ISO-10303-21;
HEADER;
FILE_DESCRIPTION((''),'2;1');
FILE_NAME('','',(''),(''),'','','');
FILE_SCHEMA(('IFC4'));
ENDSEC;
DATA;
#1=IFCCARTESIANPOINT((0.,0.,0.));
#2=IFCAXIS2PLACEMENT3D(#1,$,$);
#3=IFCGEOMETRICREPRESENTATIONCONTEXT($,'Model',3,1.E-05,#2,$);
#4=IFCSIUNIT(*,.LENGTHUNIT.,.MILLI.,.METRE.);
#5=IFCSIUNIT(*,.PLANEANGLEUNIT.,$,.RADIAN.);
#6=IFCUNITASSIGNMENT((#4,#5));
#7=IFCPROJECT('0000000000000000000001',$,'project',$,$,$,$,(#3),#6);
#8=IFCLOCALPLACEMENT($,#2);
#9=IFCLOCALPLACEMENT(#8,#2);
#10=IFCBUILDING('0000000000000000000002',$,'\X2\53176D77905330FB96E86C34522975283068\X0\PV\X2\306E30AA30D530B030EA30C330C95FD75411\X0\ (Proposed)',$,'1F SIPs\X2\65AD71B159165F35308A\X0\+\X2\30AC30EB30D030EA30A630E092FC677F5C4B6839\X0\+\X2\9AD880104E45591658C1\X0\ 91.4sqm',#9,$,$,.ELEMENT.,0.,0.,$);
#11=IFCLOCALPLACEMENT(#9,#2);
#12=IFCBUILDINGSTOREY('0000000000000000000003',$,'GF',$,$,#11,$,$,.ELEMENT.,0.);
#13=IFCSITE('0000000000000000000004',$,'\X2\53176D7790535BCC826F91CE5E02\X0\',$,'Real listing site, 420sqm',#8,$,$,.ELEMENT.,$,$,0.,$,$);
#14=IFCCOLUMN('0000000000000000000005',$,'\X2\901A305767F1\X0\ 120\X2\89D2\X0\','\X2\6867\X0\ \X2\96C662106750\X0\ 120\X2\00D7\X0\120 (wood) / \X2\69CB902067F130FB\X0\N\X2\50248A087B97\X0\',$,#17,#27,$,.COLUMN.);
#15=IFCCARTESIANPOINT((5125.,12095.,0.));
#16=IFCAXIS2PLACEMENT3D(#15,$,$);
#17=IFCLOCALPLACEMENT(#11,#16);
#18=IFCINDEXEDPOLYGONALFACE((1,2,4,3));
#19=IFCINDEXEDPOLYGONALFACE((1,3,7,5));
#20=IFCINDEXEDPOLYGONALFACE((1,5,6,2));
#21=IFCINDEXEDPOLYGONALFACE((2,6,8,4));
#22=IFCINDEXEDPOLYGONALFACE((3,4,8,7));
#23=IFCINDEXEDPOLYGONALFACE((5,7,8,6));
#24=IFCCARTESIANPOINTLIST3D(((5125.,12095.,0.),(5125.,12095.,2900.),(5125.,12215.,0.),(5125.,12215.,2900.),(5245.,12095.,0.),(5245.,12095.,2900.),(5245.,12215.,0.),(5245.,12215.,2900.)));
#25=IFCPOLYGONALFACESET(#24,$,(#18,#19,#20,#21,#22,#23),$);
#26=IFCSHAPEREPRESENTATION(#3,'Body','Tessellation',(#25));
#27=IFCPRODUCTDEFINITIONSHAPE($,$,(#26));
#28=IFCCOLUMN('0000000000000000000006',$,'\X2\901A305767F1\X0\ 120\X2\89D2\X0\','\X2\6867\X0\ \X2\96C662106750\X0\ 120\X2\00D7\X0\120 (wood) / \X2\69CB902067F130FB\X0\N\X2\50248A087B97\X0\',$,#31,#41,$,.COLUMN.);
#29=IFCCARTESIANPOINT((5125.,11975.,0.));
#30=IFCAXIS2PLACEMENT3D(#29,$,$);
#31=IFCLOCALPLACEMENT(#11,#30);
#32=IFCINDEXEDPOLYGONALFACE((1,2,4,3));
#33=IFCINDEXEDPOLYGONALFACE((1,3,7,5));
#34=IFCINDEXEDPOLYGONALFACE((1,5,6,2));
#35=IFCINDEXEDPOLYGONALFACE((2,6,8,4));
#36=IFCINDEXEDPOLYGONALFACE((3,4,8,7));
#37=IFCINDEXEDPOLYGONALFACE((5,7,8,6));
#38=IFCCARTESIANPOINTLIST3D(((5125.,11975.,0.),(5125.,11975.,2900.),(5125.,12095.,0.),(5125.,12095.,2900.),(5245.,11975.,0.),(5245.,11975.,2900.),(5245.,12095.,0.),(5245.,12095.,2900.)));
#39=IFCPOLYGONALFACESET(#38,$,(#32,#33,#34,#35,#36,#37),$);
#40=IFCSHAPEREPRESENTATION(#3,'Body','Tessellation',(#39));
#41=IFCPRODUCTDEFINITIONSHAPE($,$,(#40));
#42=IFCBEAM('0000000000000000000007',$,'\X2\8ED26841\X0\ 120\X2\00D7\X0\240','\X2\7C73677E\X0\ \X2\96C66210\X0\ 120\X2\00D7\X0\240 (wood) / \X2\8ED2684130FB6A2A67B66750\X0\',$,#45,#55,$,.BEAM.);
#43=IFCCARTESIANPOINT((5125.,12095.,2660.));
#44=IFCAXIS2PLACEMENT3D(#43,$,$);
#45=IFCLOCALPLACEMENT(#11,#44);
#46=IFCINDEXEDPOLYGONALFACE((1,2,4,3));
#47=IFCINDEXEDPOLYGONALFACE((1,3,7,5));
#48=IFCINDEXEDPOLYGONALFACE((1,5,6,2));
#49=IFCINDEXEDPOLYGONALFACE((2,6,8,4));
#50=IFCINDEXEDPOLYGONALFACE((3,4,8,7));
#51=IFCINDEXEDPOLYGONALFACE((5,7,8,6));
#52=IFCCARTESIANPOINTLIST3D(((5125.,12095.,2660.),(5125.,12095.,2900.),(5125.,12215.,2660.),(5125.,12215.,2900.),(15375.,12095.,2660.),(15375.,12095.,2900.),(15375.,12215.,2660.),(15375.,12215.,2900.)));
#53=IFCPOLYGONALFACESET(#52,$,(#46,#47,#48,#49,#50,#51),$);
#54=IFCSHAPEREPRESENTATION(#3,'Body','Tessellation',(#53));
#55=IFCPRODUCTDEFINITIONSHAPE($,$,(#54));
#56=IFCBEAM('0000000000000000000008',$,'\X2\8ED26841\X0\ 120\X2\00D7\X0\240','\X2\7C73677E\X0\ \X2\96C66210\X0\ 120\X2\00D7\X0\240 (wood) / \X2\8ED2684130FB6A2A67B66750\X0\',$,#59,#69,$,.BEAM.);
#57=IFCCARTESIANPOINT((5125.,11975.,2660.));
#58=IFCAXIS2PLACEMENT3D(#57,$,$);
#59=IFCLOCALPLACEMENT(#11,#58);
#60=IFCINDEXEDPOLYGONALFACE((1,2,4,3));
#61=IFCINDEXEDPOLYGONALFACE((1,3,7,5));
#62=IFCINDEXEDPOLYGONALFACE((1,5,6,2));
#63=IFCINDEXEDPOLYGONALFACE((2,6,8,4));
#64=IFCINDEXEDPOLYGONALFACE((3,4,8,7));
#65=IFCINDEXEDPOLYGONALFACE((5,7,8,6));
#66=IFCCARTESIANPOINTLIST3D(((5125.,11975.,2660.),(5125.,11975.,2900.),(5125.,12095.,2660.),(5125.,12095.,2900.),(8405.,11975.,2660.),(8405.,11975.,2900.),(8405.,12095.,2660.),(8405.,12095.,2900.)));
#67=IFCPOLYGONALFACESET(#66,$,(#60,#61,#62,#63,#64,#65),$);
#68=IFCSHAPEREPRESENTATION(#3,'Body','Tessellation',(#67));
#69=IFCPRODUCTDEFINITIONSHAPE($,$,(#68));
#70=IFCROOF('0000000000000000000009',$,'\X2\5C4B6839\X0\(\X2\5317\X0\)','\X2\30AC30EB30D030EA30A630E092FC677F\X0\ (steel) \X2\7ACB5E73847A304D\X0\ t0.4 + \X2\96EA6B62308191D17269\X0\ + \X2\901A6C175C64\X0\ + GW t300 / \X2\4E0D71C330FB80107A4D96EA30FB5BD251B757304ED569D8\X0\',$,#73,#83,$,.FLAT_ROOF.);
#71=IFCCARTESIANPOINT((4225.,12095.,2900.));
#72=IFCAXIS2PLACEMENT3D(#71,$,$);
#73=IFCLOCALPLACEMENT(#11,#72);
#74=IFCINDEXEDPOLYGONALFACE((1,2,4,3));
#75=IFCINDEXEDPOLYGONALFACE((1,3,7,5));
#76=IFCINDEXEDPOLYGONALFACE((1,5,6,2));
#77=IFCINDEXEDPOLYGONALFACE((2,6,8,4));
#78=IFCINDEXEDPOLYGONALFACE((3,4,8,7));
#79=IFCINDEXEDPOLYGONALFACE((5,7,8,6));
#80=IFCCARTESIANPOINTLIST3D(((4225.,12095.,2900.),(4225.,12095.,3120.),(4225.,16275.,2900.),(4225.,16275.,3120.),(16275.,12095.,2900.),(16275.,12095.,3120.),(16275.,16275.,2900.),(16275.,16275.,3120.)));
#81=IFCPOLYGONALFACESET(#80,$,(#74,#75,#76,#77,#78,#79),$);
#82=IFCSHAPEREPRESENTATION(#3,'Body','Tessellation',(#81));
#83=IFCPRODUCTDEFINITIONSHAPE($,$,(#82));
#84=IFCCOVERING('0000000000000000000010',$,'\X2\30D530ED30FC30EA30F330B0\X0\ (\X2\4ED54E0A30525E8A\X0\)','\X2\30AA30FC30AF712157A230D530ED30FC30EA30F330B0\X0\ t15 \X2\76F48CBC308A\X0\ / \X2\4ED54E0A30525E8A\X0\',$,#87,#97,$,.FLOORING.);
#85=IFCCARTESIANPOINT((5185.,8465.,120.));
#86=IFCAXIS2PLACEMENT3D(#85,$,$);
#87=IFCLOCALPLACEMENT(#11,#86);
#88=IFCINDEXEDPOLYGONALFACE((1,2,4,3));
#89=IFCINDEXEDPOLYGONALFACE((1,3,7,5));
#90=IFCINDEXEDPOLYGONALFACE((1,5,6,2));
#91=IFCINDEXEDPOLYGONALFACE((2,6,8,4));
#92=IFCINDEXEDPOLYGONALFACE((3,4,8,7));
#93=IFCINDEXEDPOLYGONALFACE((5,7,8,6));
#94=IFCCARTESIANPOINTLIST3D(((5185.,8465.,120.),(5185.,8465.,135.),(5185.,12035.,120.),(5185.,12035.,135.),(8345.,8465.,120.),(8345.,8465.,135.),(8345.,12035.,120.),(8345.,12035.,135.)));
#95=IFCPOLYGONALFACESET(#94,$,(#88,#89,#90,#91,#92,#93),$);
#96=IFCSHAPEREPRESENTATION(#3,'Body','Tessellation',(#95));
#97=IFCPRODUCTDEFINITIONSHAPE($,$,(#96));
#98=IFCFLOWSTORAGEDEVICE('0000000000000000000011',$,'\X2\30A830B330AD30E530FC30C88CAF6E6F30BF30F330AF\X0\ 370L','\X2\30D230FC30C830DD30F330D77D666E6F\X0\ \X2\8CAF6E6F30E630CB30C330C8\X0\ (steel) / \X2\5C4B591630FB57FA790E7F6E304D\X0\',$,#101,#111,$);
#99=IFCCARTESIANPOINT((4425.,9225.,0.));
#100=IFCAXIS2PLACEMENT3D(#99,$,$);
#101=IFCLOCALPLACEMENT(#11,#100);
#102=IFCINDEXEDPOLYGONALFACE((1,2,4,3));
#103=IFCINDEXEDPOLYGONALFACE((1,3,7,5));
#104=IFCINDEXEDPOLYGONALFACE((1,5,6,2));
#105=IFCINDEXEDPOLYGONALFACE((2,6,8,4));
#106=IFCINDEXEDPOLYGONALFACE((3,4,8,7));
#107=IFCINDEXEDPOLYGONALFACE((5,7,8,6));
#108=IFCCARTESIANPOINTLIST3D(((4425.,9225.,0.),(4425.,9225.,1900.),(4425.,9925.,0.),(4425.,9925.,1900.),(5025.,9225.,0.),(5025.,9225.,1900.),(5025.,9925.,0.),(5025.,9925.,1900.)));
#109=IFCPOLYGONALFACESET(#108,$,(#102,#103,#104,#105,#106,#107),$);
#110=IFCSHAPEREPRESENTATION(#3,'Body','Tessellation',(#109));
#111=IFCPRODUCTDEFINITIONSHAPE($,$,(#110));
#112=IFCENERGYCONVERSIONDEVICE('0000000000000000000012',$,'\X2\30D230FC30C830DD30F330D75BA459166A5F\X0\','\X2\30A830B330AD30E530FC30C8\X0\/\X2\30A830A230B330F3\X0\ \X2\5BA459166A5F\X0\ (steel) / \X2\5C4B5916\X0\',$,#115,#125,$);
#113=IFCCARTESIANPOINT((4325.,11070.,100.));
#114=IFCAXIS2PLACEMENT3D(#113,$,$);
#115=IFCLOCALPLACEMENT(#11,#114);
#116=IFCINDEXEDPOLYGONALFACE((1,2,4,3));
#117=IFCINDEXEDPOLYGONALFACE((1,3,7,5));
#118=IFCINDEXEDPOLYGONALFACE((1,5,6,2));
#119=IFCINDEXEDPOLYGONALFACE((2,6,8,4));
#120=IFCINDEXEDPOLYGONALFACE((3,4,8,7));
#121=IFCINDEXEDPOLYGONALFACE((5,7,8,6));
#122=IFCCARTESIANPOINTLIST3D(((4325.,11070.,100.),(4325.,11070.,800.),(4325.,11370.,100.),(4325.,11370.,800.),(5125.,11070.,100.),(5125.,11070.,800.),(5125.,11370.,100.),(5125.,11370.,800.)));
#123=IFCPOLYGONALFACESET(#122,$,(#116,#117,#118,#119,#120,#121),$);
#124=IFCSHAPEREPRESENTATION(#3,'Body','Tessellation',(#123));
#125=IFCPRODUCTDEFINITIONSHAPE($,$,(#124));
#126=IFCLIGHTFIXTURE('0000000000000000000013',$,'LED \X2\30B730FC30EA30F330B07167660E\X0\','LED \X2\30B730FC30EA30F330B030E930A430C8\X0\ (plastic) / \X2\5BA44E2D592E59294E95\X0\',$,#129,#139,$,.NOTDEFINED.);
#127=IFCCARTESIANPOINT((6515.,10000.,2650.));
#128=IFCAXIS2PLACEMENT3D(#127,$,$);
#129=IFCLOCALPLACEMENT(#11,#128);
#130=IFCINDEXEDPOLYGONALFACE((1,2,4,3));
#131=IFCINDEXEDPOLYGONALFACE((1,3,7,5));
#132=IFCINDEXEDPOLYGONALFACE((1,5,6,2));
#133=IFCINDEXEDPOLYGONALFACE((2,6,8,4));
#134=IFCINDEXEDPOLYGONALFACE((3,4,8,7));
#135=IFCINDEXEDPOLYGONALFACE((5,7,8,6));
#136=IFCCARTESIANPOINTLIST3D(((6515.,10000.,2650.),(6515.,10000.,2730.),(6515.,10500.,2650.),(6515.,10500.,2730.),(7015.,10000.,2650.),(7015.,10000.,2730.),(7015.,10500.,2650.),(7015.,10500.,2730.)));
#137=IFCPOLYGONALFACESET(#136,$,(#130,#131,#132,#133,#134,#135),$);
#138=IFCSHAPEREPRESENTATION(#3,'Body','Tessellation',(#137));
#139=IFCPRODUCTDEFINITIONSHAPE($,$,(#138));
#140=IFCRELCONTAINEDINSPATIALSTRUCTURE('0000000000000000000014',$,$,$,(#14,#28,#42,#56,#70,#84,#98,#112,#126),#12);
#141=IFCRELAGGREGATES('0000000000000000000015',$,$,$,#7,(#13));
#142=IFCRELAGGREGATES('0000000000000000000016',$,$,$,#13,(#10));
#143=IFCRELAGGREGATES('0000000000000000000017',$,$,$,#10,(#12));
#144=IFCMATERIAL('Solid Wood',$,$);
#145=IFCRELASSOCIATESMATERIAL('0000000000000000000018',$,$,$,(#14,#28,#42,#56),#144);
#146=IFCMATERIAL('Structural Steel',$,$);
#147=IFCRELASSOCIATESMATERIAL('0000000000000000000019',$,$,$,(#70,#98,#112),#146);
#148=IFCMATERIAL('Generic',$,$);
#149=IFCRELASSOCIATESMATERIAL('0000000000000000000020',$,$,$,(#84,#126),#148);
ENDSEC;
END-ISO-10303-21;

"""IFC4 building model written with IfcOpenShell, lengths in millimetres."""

from ifc_helpers import new_model, si_unit, frame, frame_2d, origin, place, context, project, spatial, rectangle, extrude, material, element, save


model = new_model("IFC4")

# Units and contexts
model_context = context("Model", 3, precision=1e-05, world=origin())
ifc_project = project(units=[si_unit("LENGTHUNIT", "METRE", prefix="MILLI"), si_unit("PLANEANGLEUNIT", "RADIAN")], contexts=[model_context])

# Site, building, storey
site_placement = place(None, origin())
site = spatial("IfcSite", under=ifc_project, at=site_placement, Name="北海道富良野市", ObjectType="Real listing site, 420sqm", CompositionType="ELEMENT", RefElevation=0.0)
building_placement = place(site_placement, origin())
building = spatial("IfcBuilding", under=site, at=building_placement, Name="北海道・雨水利用とPVのオフグリッド志向 (Proposed)", ObjectType="1F SIPs断熱外張り+ガルバリウム鋼板屋根+高耐久外壁 91.4sqm", CompositionType="ELEMENT", ElevationOfRefHeight=0.0, ElevationOfTerrain=0.0)
storey_placement = place(building_placement, origin())
storey = spatial("IfcBuildingStorey", under=building, at=storey_placement, Name="GF", CompositionType="ELEMENT", Elevation=0.0)

# Columns
ifc_material_1 = material(Name="Solid Wood")
column_1_placement = place(storey_placement, frame((5125.0, 12095.0, 0.0)))
element("IfcColumn", 1, at=column_1_placement, inside=storey, material=ifc_material_1, Name="通し柱 120角", Description="桧 集成材 120×120 (wood) / 構造柱・N値計算", PredefinedType="COLUMN", context=model_context, shape_type="SweptSolid", body=[
    extrude(rectangle(XDim=120.0, YDim=120.0, at=frame_2d((60.0, 60.0))), frame((5125.0, 12095.0, 0.0)), (0.0, 0.0, 1.0), 2900.0),
])
column_2_placement = place(storey_placement, frame((5125.0, 11975.0, 0.0)))
element("IfcColumn", 2, at=column_2_placement, inside=storey, material=ifc_material_1, Name="通し柱 120角", Description="桧 集成材 120×120 (wood) / 構造柱・N値計算", PredefinedType="COLUMN", context=model_context, shape_type="SweptSolid", body=[
    extrude(rectangle(XDim=120.0, YDim=120.0, at=frame_2d((60.0, 60.0))), frame((5125.0, 11975.0, 0.0)), (0.0, 0.0, 1.0), 2900.0),
])

# Beams
beam_1_placement = place(storey_placement, frame((5125.0, 12095.0, 2660.0)))
element("IfcBeam", 3, at=beam_1_placement, inside=storey, material=ifc_material_1, Name="軒桁 120×240", Description="米松 集成 120×240 (wood) / 軒桁・横架材", PredefinedType="BEAM", context=model_context, shape_type="SweptSolid", body=[
    extrude(rectangle(XDim=10250.0, YDim=120.0, at=frame_2d((5125.0, 60.0))), frame((5125.0, 12095.0, 2660.0)), (0.0, 0.0, 1.0), 240.0),
])
beam_2_placement = place(storey_placement, frame((5125.0, 11975.0, 2660.0)))
element("IfcBeam", 4, at=beam_2_placement, inside=storey, material=ifc_material_1, Name="軒桁 120×240", Description="米松 集成 120×240 (wood) / 軒桁・横架材", PredefinedType="BEAM", context=model_context, shape_type="SweptSolid", body=[
    extrude(rectangle(XDim=3280.0, YDim=120.0, at=frame_2d((1640.0, 60.0))), frame((5125.0, 11975.0, 2660.0)), (0.0, 0.0, 1.0), 240.0),
])

# Roof
ifc_material_2 = material(Name="Structural Steel")
roof_placement = place(storey_placement, frame((4225.0, 12095.0, 2900.0)))
element("IfcRoof", 5, at=roof_placement, inside=storey, material=ifc_material_2, Name="屋根(北)", Description="ガルバリウム鋼板 (steel) 立平葺き t0.4 + 雪止め金物 + 通気層 + GW t300 / 不燃・耐積雪・寒冷地仕様", PredefinedType="FLAT_ROOF", context=model_context, shape_type="SweptSolid", body=[
    extrude(rectangle(XDim=12050.0, YDim=4180.0, at=frame_2d((6025.0, 2090.0))), frame((4225.0, 12095.0, 2900.0)), (0.0, 0.0, 1.0), 220.0),
])

# Covering
ifc_material_3 = material(Name="Generic")
covering_placement = place(storey_placement, frame((5185.0, 8465.0, 120.0)))
element("IfcCovering", 6, at=covering_placement, inside=storey, material=ifc_material_3, Name="フローリング (仕上げ床)", Description="オーク無垢フローリング t15 直貼り / 仕上げ床", PredefinedType="FLOORING", context=model_context, shape_type="SweptSolid", body=[
    extrude(rectangle(XDim=3160.0, YDim=3570.0, at=frame_2d((1580.0, 1785.0))), frame((5185.0, 8465.0, 120.0)), (0.0, 0.0, 1.0), 15.0),
])

# Flow storage device
flow_storage_device_placement = place(storey_placement, frame((4425.0, 9225.0, 0.0)))
element("IfcFlowStorageDevice", 7, at=flow_storage_device_placement, inside=storey, material=ifc_material_2, Name="エコキュート貯湯タンク 370L", Description="ヒートポンプ給湯 貯湯ユニット (steel) / 屋外・基礎置き", context=model_context, shape_type="SweptSolid", body=[
    extrude(rectangle(XDim=600.0, YDim=700.0, at=frame_2d((300.0, 350.0))), frame((4425.0, 9225.0, 0.0)), (0.0, 0.0, 1.0), 1900.0),
])

# Energy conversion device
energy_conversion_device_placement = place(storey_placement, frame((4325.0, 11070.0, 100.0)))
element("IfcEnergyConversionDevice", 8, at=energy_conversion_device_placement, inside=storey, material=ifc_material_2, Name="ヒートポンプ室外機", Description="エコキュート/エアコン 室外機 (steel) / 屋外", context=model_context, shape_type="SweptSolid", body=[
    extrude(rectangle(XDim=800.0, YDim=300.0, at=frame_2d((400.0, 150.0))), frame((4325.0, 11070.0, 100.0)), (0.0, 0.0, 1.0), 700.0),
])

# Light fixture
light_fixture_placement = place(storey_placement, frame((6515.0, 10000.0, 2650.0)))
element("IfcLightFixture", 9, at=light_fixture_placement, inside=storey, material=ifc_material_3, Name="LED シーリング照明", Description="LED シーリングライト (plastic) / 室中央天井", PredefinedType="NOTDEFINED", context=model_context, shape_type="SweptSolid", body=[
    extrude(rectangle(XDim=500.0, YDim=500.0, at=frame_2d((250.0, 250.0))), frame((6515.0, 10000.0, 2650.0)), (0.0, 0.0, 1.0), 80.0),
])

save(model, "model.ifc")
